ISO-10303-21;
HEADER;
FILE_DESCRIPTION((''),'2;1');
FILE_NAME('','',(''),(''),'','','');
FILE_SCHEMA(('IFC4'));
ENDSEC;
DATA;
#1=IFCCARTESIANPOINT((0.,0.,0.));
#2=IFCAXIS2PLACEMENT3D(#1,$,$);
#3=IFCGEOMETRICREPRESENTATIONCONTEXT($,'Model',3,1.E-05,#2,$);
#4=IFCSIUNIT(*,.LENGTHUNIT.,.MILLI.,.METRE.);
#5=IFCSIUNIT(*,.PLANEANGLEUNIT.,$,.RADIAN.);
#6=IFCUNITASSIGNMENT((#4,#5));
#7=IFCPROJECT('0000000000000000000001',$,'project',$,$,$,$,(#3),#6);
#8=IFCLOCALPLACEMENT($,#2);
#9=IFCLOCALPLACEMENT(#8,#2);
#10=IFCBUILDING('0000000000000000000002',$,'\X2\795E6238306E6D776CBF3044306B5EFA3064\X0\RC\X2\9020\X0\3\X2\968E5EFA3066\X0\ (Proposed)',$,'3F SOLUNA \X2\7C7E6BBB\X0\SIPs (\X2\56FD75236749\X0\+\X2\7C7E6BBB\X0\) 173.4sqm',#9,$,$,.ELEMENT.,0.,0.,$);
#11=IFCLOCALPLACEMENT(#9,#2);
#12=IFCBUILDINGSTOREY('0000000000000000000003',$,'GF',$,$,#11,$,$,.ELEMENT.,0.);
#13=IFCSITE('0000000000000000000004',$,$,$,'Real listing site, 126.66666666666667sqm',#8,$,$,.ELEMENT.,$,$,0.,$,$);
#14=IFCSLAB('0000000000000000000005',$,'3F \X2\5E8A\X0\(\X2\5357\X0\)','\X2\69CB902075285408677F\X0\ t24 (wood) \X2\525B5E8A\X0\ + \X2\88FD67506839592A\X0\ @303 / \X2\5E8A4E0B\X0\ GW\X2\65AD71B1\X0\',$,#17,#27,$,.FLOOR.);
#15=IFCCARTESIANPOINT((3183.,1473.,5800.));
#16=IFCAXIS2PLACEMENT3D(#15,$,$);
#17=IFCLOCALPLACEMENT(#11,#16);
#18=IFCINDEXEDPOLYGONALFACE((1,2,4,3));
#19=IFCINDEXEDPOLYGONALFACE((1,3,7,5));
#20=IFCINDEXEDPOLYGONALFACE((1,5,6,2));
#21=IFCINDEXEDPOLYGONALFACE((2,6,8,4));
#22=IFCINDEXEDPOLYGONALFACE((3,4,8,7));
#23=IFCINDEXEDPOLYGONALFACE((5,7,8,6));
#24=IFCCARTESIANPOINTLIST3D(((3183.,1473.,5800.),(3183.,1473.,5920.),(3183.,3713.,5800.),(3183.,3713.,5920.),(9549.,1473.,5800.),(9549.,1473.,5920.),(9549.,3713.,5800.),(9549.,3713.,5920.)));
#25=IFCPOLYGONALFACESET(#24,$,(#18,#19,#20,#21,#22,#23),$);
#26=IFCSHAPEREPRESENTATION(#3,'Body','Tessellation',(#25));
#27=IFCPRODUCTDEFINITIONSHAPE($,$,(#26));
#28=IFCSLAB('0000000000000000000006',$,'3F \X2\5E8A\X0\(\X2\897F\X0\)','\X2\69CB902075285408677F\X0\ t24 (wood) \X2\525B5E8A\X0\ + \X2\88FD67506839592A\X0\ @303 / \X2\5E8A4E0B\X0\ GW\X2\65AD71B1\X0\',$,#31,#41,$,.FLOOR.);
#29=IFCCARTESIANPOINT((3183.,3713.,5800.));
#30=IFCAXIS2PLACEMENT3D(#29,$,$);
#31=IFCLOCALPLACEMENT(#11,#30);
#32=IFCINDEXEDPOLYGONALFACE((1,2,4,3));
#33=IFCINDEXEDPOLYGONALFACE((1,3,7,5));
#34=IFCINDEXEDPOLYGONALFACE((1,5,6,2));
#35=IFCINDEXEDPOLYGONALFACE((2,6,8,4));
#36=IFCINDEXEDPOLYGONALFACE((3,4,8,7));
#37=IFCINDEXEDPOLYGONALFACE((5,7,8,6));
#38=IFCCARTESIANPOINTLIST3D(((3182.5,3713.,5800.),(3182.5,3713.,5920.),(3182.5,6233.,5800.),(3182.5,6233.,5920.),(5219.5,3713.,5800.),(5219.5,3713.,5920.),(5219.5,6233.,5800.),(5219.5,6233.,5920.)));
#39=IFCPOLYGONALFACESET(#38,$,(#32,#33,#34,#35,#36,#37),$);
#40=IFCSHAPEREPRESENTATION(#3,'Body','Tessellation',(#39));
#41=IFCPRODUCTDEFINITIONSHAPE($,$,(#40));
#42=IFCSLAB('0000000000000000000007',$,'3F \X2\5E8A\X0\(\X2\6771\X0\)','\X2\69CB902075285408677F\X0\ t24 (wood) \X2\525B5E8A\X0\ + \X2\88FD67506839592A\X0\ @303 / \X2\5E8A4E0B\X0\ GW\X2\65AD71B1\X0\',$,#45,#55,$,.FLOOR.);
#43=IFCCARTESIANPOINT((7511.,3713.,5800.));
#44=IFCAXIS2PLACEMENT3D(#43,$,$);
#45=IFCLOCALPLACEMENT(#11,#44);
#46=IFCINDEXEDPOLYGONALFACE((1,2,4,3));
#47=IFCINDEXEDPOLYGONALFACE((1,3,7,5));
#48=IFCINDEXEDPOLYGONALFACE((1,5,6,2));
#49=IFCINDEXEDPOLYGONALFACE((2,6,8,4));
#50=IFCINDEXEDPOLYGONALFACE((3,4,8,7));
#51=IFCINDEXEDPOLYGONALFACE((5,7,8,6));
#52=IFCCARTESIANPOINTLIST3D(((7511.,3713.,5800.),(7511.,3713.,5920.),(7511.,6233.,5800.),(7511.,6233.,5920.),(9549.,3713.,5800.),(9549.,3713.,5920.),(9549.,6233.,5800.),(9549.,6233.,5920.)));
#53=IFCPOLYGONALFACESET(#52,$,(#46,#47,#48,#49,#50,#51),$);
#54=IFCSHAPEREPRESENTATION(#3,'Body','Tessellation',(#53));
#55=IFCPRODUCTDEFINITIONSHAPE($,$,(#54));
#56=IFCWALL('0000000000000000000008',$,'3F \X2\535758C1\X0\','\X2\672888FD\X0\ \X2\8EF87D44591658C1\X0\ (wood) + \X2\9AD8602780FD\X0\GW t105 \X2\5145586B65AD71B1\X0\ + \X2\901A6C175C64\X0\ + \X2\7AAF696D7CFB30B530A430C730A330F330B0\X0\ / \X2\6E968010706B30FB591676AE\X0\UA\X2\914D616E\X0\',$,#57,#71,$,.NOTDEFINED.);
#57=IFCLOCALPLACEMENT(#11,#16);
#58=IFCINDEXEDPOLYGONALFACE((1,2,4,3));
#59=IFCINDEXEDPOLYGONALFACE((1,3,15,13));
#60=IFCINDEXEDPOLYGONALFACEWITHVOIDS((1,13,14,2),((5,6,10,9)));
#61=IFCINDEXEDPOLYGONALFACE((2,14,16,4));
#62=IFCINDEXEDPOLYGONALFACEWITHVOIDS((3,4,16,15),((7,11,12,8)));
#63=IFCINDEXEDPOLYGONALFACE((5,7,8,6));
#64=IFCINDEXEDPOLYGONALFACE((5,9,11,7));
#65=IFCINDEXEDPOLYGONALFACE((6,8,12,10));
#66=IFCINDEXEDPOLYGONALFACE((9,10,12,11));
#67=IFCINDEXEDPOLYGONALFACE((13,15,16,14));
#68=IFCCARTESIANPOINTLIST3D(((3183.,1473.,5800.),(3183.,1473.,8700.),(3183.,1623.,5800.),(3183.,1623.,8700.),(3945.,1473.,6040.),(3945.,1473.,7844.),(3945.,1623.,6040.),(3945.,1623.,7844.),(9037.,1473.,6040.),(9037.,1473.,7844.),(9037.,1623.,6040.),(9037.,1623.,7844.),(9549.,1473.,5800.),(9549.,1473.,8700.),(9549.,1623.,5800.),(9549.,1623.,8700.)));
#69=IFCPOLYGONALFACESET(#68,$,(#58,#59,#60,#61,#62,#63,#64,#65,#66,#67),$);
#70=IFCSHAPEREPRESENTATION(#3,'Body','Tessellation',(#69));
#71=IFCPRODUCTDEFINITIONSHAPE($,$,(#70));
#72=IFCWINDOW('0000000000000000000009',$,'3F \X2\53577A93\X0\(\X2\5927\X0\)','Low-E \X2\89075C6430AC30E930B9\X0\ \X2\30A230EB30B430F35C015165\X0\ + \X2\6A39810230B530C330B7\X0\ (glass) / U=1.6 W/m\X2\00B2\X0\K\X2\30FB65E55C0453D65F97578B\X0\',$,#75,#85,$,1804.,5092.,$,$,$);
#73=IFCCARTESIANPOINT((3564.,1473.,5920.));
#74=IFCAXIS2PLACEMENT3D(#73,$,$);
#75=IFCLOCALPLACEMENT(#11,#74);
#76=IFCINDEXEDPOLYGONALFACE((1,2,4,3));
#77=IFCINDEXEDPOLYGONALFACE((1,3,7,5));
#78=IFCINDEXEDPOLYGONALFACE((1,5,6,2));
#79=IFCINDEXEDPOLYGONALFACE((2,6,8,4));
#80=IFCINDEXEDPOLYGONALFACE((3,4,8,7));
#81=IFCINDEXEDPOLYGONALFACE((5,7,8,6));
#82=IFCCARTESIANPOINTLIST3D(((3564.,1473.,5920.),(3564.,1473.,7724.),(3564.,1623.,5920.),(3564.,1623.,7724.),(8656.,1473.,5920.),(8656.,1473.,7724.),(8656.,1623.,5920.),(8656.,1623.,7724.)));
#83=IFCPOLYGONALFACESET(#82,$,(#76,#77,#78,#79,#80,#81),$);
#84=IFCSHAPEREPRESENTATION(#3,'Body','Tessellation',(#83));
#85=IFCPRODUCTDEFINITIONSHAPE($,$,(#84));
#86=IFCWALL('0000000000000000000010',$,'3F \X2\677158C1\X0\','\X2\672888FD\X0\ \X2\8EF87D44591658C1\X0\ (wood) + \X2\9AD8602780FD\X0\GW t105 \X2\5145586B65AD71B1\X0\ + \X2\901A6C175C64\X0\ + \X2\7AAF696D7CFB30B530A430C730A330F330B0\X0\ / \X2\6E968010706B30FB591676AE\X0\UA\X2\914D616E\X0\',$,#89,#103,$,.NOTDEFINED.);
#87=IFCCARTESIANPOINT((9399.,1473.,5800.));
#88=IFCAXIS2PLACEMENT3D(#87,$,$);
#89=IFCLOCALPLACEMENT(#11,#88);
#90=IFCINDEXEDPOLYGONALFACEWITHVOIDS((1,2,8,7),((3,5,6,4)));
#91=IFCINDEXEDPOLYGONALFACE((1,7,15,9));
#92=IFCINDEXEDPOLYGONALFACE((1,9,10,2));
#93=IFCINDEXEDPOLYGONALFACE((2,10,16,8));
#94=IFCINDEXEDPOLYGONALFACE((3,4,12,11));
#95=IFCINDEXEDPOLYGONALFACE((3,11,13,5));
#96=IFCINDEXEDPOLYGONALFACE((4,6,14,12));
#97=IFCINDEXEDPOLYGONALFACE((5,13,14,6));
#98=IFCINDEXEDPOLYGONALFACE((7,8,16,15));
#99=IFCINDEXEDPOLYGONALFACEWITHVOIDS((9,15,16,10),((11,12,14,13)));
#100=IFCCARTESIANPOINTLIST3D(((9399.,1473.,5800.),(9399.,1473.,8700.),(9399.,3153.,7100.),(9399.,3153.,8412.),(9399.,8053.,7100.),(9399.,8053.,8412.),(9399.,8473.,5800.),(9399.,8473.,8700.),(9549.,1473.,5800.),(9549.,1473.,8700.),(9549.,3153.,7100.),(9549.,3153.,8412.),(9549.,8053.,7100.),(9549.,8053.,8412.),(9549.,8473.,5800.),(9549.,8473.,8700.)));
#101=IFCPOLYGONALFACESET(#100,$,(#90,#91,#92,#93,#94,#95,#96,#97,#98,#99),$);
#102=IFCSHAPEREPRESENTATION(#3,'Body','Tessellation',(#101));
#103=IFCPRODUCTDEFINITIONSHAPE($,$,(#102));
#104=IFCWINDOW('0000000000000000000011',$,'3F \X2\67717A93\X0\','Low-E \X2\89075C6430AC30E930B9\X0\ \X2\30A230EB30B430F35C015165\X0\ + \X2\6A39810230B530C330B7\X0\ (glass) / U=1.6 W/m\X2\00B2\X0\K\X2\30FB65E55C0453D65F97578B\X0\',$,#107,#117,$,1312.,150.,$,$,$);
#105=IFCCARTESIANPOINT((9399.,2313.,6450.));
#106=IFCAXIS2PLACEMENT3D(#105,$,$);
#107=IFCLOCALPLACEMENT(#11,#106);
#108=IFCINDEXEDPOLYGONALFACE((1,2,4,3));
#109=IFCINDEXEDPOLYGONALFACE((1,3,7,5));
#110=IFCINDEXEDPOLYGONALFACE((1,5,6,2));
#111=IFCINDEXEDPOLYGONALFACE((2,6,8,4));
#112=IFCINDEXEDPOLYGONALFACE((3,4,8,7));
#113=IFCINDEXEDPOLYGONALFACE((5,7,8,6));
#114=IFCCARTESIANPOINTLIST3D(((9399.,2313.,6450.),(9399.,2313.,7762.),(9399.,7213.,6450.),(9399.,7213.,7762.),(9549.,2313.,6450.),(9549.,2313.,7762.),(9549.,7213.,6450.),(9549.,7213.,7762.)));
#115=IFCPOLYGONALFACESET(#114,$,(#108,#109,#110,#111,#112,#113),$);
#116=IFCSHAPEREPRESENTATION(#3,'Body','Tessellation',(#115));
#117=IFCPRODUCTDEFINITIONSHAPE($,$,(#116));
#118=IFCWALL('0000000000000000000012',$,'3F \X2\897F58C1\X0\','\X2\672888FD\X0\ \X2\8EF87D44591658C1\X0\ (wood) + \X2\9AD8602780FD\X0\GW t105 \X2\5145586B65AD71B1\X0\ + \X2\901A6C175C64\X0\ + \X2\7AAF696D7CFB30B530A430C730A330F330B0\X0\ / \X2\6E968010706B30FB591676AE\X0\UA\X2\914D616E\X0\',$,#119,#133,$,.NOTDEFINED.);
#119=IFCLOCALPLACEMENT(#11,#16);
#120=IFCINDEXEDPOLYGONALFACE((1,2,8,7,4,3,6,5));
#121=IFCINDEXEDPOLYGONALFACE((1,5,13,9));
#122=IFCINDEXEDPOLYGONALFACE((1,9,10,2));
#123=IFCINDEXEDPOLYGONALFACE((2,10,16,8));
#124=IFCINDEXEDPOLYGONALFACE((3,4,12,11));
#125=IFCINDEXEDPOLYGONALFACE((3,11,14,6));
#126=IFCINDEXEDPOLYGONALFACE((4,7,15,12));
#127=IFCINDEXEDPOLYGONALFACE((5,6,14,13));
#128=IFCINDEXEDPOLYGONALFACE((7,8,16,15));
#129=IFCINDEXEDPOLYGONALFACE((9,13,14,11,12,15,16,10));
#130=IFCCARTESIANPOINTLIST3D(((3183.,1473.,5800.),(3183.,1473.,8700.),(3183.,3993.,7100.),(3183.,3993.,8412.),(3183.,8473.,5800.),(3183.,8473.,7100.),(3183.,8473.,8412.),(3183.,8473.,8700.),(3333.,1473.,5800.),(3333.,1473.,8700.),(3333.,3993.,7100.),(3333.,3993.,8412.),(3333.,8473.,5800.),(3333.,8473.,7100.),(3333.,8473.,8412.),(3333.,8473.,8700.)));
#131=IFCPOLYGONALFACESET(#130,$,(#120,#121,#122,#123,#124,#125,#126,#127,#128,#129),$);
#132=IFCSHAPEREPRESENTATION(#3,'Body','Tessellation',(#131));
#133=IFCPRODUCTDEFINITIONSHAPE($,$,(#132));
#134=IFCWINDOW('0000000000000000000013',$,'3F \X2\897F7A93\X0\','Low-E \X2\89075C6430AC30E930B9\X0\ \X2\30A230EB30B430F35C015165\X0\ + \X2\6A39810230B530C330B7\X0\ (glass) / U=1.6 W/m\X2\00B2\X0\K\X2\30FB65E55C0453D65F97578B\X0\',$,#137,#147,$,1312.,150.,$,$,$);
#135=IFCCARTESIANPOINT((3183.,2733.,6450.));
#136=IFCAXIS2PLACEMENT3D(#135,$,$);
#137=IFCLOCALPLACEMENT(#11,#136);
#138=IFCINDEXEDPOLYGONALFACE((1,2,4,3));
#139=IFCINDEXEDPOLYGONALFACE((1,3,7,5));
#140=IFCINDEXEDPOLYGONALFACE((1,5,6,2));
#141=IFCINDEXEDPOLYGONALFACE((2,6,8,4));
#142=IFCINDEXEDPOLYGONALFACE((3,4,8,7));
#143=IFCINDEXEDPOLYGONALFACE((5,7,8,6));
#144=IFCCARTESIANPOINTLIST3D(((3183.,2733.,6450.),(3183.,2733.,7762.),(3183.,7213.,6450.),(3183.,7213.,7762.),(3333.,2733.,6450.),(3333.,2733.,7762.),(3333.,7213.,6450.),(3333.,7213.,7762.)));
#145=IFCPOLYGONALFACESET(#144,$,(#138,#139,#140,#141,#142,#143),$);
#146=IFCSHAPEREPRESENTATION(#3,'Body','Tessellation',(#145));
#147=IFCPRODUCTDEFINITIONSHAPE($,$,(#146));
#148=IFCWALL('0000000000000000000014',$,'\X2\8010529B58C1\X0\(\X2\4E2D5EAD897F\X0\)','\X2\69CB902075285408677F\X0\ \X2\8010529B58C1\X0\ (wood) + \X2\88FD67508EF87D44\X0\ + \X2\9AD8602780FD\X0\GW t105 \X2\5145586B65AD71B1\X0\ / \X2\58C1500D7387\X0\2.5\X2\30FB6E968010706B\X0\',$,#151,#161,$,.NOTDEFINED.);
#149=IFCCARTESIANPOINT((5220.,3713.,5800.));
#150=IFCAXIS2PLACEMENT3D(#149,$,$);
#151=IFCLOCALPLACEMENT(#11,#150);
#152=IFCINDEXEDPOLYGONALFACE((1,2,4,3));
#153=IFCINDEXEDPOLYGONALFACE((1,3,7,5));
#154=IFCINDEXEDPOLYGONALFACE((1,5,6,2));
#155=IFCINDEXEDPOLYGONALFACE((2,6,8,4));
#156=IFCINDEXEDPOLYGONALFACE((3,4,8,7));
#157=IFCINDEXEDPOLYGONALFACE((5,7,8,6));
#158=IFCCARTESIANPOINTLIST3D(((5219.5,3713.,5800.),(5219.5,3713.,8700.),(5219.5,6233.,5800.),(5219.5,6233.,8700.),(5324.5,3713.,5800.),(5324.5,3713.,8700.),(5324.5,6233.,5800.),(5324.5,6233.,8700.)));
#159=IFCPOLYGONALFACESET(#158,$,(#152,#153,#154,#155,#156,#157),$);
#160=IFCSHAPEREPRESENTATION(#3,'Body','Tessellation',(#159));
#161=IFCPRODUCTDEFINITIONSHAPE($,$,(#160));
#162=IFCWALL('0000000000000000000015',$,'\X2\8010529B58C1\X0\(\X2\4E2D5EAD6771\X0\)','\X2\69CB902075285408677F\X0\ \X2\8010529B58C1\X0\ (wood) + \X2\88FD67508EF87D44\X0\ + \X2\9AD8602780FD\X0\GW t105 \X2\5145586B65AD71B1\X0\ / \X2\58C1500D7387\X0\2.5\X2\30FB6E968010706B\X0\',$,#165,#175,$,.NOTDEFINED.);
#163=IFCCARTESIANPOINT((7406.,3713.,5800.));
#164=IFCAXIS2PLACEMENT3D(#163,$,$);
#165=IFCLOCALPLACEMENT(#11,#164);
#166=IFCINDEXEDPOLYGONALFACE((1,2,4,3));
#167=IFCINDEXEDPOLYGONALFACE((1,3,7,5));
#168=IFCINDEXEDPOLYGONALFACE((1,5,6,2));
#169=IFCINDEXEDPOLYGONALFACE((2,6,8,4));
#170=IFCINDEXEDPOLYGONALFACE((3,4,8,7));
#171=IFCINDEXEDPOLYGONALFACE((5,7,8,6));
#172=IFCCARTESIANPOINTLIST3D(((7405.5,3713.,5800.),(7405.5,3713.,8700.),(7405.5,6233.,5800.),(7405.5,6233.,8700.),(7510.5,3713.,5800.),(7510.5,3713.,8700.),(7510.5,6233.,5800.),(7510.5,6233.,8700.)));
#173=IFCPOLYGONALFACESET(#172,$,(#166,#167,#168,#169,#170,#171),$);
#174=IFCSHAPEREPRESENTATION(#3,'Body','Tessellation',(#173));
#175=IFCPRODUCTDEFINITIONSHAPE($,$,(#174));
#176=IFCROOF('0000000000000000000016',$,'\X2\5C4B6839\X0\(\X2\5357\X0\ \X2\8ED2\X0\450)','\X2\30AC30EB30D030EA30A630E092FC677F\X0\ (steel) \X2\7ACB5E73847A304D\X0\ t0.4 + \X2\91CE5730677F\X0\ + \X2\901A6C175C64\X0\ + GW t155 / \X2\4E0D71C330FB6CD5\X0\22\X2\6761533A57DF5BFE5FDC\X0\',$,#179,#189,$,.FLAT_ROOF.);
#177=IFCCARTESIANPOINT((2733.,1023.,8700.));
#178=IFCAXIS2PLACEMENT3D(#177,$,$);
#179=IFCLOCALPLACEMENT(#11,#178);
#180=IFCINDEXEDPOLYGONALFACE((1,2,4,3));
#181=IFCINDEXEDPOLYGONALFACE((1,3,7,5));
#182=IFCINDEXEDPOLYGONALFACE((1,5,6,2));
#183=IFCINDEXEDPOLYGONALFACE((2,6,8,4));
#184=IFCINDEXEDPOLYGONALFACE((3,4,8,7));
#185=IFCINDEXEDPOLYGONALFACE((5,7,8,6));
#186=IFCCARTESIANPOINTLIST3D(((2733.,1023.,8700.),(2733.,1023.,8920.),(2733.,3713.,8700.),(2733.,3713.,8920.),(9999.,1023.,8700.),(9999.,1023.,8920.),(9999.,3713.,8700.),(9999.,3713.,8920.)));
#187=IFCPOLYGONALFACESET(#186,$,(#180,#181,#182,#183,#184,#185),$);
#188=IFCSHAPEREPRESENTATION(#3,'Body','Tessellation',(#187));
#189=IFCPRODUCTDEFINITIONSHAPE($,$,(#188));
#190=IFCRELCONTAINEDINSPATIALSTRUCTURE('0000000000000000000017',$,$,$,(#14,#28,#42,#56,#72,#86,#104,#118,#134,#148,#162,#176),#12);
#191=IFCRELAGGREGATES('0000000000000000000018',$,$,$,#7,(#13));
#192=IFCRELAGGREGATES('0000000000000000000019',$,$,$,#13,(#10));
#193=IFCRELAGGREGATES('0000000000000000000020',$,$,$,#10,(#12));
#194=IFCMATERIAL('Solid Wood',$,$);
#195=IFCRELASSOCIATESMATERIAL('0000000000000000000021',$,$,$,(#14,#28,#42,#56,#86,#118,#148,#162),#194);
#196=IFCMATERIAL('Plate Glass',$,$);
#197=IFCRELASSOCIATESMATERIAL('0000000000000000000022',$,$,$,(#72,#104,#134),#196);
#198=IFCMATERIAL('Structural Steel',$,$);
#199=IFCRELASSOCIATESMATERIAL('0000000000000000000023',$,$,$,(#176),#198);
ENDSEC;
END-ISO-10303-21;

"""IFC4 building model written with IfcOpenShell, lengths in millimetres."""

from ifc_helpers import new_model, si_unit, frame, frame_2d, origin, place, context, project, spatial, rectangle, extrude, material, element, fill, save


model = new_model("IFC4")

# Units and contexts
model_context = context("Model", 3, precision=1e-05, world=origin())
ifc_project = project(units=[si_unit("LENGTHUNIT", "METRE", prefix="MILLI"), si_unit("PLANEANGLEUNIT", "RADIAN")], contexts=[model_context])

# Site, building, storey
site_placement = place(None, origin())
site = spatial("IfcSite", under=ifc_project, at=site_placement, ObjectType="Real listing site, 126.66666666666667sqm", CompositionType="ELEMENT", RefElevation=0.0)
building_placement = place(site_placement, origin())
building = spatial("IfcBuilding", under=site, at=building_placement, Name="神戸の海沿いに建つRC造3階建て (Proposed)", ObjectType="3F SOLUNA 籾殻SIPs (国産杉+籾殻) 173.4sqm", CompositionType="ELEMENT", ElevationOfRefHeight=0.0, ElevationOfTerrain=0.0)
storey_placement = place(building_placement, origin())
storey = spatial("IfcBuildingStorey", under=building, at=storey_placement, Name="GF", CompositionType="ELEMENT", Elevation=0.0)

# Slabs
ifc_material_1 = material(Name="Solid Wood")
slab_1_placement = place(storey_placement, frame((3183.0, 1473.0, 5800.0)))
element("IfcSlab", 1, at=slab_1_placement, inside=storey, material=ifc_material_1, Name="3F 床(南)", Description="構造用合板 t24 (wood) 剛床 + 製材根太 @303 / 床下 GW断熱", PredefinedType="FLOOR", context=model_context, shape_type="SweptSolid", body=[
    extrude(rectangle(XDim=6366.0, YDim=2240.0, at=frame_2d((3183.0, 1120.0))), frame((3183.0, 1473.0, 5800.0)), (0.0, 0.0, 1.0), 120.0),
])
slab_2_placement = place(storey_placement, frame((3183.0, 3713.0, 5800.0)))
element("IfcSlab", 2, at=slab_2_placement, inside=storey, material=ifc_material_1, Name="3F 床(西)", Description="構造用合板 t24 (wood) 剛床 + 製材根太 @303 / 床下 GW断熱", PredefinedType="FLOOR", context=model_context, shape_type="SweptSolid", body=[
    extrude(rectangle(XDim=2037.0, YDim=2520.0, at=frame_2d((1018.0, 1260.0))), frame((3183.0, 3713.0, 5800.0)), (0.0, 0.0, 1.0), 120.0),
])
slab_3_placement = place(storey_placement, frame((7511.0, 3713.0, 5800.0)))
element("IfcSlab", 3, at=slab_3_placement, inside=storey, material=ifc_material_1, Name="3F 床(東)", Description="構造用合板 t24 (wood) 剛床 + 製材根太 @303 / 床下 GW断熱", PredefinedType="FLOOR", context=model_context, shape_type="SweptSolid", body=[
    extrude(rectangle(XDim=2038.0, YDim=2520.0, at=frame_2d((1019.0, 1260.0))), frame((7511.0, 3713.0, 5800.0)), (0.0, 0.0, 1.0), 120.0),
])

# Walls, openings, windows
wall_1_placement = place(storey_placement, frame((3183.0, 1473.0, 5800.0)))
wall_1 = element("IfcWall", 4, at=wall_1_placement, inside=storey, material=ifc_material_1, Name="3F 南壁", Description="木製 軸組外壁 (wood) + 高性能GW t105 充填断熱 + 通気層 + 窯業系サイディング / 準耐火・外皮UA配慮", PredefinedType="NOTDEFINED", context=model_context, shape_type="SweptSolid", body=[
    extrude(rectangle(XDim=6366.0, YDim=150.0, at=frame_2d((3183.0, 75.0))), frame((3183.0, 1473.0, 5800.0)), (0.0, 0.0, 1.0), 2900.0),
])
opening_1_placement = place(storey_placement, frame((3564.0, 1473.0, 5920.0)))
opening_1 = element("IfcOpeningElement", 5, at=opening_1_placement, cuts=wall_1, PredefinedType="NOTDEFINED", context=model_context, shape_type="SweptSolid", body=[
    extrude(rectangle(XDim=5092.0, YDim=150.0, at=frame_2d((2546.0, 75.0))), frame((3564.0, 1473.0, 5920.0)), (0.0, 0.0, 1.0), 1804.0),
])
ifc_material_2 = material(Name="Plate Glass")
window_1_placement = place(storey_placement, frame((3564.0, 1473.0, 5920.0)))
window_1 = element("IfcWindow", 6, at=window_1_placement, inside=storey, material=ifc_material_2, Name="3F 南窓(大)", Description="Low-E 複層ガラス アルゴン封入 + 樹脂サッシ (glass) / U=1.6 W/m²K・日射取得型", OverallHeight=1804.0, OverallWidth=5092.0, context=model_context, shape_type="SweptSolid", body=[
    extrude(rectangle(XDim=5092.0, YDim=150.0, at=frame_2d((2546.0, 75.0))), frame((3564.0, 1473.0, 5920.0)), (0.0, 0.0, 1.0), 1804.0),
])
fill(opening_1, window_1)
wall_2_placement = place(storey_placement, frame((9399.0, 1473.0, 5800.0)))
wall_2 = element("IfcWall", 7, at=wall_2_placement, inside=storey, material=ifc_material_1, Name="3F 東壁", Description="木製 軸組外壁 (wood) + 高性能GW t105 充填断熱 + 通気層 + 窯業系サイディング / 準耐火・外皮UA配慮", PredefinedType="NOTDEFINED", context=model_context, shape_type="SweptSolid", body=[
    extrude(rectangle(XDim=150.0, YDim=7000.0, at=frame_2d((75.0, 3500.0))), frame((9399.0, 1473.0, 5800.0)), (0.0, 0.0, 1.0), 2900.0),
])
opening_2_placement = place(storey_placement, frame((9399.0, 2313.0, 6450.0)))
opening_2 = element("IfcOpeningElement", 8, at=opening_2_placement, cuts=wall_2, PredefinedType="NOTDEFINED", context=model_context, shape_type="SweptSolid", body=[
    extrude(rectangle(XDim=150.0, YDim=4900.0, at=frame_2d((75.0, 2450.0))), frame((9399.0, 2313.0, 6450.0)), (0.0, 0.0, 1.0), 1312.0),
])
window_2_placement = place(storey_placement, frame((9399.0, 2313.0, 6450.0)))
window_2 = element("IfcWindow", 9, at=window_2_placement, inside=storey, material=ifc_material_2, Name="3F 東窓", Description="Low-E 複層ガラス アルゴン封入 + 樹脂サッシ (glass) / U=1.6 W/m²K・日射取得型", OverallHeight=1312.0, OverallWidth=150.0, context=model_context, shape_type="SweptSolid", body=[
    extrude(rectangle(XDim=150.0, YDim=4900.0, at=frame_2d((75.0, 2450.0))), frame((9399.0, 2313.0, 6450.0)), (0.0, 0.0, 1.0), 1312.0),
])
fill(opening_2, window_2)
wall_3_placement = place(storey_placement, frame((3183.0, 1473.0, 5800.0)))
wall_3 = element("IfcWall", 10, at=wall_3_placement, inside=storey, material=ifc_material_1, Name="3F 西壁", Description="木製 軸組外壁 (wood) + 高性能GW t105 充填断熱 + 通気層 + 窯業系サイディング / 準耐火・外皮UA配慮", PredefinedType="NOTDEFINED", context=model_context, shape_type="SweptSolid", body=[
    extrude(rectangle(XDim=150.0, YDim=7000.0, at=frame_2d((75.0, 3500.0))), frame((3183.0, 1473.0, 5800.0)), (0.0, 0.0, 1.0), 2900.0),
])
opening_3_placement = place(storey_placement, frame((3183.0, 2733.0, 6450.0)))
opening_3 = element("IfcOpeningElement", 11, at=opening_3_placement, cuts=wall_3, PredefinedType="NOTDEFINED", context=model_context, shape_type="SweptSolid", body=[
    extrude(rectangle(XDim=150.0, YDim=4480.0, at=frame_2d((75.0, 2240.0))), frame((3183.0, 2733.0, 6450.0)), (0.0, 0.0, 1.0), 1312.0),
])
window_3_placement = place(storey_placement, frame((3183.0, 2733.0, 6450.0)))
window_3 = element("IfcWindow", 12, at=window_3_placement, inside=storey, material=ifc_material_2, Name="3F 西窓", Description="Low-E 複層ガラス アルゴン封入 + 樹脂サッシ (glass) / U=1.6 W/m²K・日射取得型", OverallHeight=1312.0, OverallWidth=150.0, context=model_context, shape_type="SweptSolid", body=[
    extrude(rectangle(XDim=150.0, YDim=4480.0, at=frame_2d((75.0, 2240.0))), frame((3183.0, 2733.0, 6450.0)), (0.0, 0.0, 1.0), 1312.0),
])
fill(opening_3, window_3)

# Walls
wall_4_placement = place(storey_placement, frame((5220.0, 3713.0, 5800.0)))
element("IfcWall", 13, at=wall_4_placement, inside=storey, material=ifc_material_1, Name="耐力壁(中庭西)", Description="構造用合板 耐力壁 (wood) + 製材軸組 + 高性能GW t105 充填断熱 / 壁倍率2.5・準耐火", PredefinedType="NOTDEFINED", context=model_context, shape_type="SweptSolid", body=[
    extrude(rectangle(XDim=105.0, YDim=2520.0, at=frame_2d((52.0, 1260.0))), frame((5220.0, 3713.0, 5800.0)), (0.0, 0.0, 1.0), 2900.0),
])
wall_5_placement = place(storey_placement, frame((7406.0, 3713.0, 5800.0)))
element("IfcWall", 14, at=wall_5_placement, inside=storey, material=ifc_material_1, Name="耐力壁(中庭東)", Description="構造用合板 耐力壁 (wood) + 製材軸組 + 高性能GW t105 充填断熱 / 壁倍率2.5・準耐火", PredefinedType="NOTDEFINED", context=model_context, shape_type="SweptSolid", body=[
    extrude(rectangle(XDim=105.0, YDim=2520.0, at=frame_2d((52.0, 1260.0))), frame((7406.0, 3713.0, 5800.0)), (0.0, 0.0, 1.0), 2900.0),
])

# Roof
ifc_material_3 = material(Name="Structural Steel")
roof_1_placement = place(storey_placement, frame((2733.0, 1023.0, 8700.0)))
element("IfcRoof", 15, at=roof_1_placement, inside=storey, material=ifc_material_3, Name="屋根(南 軒450)", Description="ガルバリウム鋼板 (steel) 立平葺き t0.4 + 野地板 + 通気層 + GW t155 / 不燃・法22条区域対応", PredefinedType="FLAT_ROOF", context=model_context, shape_type="SweptSolid", body=[
    extrude(rectangle(XDim=7266.0, YDim=2690.0, at=frame_2d((3633.0, 1345.0))), frame((2733.0, 1023.0, 8700.0)), (0.0, 0.0, 1.0), 220.0),
])

save(model, "model.ifc")
